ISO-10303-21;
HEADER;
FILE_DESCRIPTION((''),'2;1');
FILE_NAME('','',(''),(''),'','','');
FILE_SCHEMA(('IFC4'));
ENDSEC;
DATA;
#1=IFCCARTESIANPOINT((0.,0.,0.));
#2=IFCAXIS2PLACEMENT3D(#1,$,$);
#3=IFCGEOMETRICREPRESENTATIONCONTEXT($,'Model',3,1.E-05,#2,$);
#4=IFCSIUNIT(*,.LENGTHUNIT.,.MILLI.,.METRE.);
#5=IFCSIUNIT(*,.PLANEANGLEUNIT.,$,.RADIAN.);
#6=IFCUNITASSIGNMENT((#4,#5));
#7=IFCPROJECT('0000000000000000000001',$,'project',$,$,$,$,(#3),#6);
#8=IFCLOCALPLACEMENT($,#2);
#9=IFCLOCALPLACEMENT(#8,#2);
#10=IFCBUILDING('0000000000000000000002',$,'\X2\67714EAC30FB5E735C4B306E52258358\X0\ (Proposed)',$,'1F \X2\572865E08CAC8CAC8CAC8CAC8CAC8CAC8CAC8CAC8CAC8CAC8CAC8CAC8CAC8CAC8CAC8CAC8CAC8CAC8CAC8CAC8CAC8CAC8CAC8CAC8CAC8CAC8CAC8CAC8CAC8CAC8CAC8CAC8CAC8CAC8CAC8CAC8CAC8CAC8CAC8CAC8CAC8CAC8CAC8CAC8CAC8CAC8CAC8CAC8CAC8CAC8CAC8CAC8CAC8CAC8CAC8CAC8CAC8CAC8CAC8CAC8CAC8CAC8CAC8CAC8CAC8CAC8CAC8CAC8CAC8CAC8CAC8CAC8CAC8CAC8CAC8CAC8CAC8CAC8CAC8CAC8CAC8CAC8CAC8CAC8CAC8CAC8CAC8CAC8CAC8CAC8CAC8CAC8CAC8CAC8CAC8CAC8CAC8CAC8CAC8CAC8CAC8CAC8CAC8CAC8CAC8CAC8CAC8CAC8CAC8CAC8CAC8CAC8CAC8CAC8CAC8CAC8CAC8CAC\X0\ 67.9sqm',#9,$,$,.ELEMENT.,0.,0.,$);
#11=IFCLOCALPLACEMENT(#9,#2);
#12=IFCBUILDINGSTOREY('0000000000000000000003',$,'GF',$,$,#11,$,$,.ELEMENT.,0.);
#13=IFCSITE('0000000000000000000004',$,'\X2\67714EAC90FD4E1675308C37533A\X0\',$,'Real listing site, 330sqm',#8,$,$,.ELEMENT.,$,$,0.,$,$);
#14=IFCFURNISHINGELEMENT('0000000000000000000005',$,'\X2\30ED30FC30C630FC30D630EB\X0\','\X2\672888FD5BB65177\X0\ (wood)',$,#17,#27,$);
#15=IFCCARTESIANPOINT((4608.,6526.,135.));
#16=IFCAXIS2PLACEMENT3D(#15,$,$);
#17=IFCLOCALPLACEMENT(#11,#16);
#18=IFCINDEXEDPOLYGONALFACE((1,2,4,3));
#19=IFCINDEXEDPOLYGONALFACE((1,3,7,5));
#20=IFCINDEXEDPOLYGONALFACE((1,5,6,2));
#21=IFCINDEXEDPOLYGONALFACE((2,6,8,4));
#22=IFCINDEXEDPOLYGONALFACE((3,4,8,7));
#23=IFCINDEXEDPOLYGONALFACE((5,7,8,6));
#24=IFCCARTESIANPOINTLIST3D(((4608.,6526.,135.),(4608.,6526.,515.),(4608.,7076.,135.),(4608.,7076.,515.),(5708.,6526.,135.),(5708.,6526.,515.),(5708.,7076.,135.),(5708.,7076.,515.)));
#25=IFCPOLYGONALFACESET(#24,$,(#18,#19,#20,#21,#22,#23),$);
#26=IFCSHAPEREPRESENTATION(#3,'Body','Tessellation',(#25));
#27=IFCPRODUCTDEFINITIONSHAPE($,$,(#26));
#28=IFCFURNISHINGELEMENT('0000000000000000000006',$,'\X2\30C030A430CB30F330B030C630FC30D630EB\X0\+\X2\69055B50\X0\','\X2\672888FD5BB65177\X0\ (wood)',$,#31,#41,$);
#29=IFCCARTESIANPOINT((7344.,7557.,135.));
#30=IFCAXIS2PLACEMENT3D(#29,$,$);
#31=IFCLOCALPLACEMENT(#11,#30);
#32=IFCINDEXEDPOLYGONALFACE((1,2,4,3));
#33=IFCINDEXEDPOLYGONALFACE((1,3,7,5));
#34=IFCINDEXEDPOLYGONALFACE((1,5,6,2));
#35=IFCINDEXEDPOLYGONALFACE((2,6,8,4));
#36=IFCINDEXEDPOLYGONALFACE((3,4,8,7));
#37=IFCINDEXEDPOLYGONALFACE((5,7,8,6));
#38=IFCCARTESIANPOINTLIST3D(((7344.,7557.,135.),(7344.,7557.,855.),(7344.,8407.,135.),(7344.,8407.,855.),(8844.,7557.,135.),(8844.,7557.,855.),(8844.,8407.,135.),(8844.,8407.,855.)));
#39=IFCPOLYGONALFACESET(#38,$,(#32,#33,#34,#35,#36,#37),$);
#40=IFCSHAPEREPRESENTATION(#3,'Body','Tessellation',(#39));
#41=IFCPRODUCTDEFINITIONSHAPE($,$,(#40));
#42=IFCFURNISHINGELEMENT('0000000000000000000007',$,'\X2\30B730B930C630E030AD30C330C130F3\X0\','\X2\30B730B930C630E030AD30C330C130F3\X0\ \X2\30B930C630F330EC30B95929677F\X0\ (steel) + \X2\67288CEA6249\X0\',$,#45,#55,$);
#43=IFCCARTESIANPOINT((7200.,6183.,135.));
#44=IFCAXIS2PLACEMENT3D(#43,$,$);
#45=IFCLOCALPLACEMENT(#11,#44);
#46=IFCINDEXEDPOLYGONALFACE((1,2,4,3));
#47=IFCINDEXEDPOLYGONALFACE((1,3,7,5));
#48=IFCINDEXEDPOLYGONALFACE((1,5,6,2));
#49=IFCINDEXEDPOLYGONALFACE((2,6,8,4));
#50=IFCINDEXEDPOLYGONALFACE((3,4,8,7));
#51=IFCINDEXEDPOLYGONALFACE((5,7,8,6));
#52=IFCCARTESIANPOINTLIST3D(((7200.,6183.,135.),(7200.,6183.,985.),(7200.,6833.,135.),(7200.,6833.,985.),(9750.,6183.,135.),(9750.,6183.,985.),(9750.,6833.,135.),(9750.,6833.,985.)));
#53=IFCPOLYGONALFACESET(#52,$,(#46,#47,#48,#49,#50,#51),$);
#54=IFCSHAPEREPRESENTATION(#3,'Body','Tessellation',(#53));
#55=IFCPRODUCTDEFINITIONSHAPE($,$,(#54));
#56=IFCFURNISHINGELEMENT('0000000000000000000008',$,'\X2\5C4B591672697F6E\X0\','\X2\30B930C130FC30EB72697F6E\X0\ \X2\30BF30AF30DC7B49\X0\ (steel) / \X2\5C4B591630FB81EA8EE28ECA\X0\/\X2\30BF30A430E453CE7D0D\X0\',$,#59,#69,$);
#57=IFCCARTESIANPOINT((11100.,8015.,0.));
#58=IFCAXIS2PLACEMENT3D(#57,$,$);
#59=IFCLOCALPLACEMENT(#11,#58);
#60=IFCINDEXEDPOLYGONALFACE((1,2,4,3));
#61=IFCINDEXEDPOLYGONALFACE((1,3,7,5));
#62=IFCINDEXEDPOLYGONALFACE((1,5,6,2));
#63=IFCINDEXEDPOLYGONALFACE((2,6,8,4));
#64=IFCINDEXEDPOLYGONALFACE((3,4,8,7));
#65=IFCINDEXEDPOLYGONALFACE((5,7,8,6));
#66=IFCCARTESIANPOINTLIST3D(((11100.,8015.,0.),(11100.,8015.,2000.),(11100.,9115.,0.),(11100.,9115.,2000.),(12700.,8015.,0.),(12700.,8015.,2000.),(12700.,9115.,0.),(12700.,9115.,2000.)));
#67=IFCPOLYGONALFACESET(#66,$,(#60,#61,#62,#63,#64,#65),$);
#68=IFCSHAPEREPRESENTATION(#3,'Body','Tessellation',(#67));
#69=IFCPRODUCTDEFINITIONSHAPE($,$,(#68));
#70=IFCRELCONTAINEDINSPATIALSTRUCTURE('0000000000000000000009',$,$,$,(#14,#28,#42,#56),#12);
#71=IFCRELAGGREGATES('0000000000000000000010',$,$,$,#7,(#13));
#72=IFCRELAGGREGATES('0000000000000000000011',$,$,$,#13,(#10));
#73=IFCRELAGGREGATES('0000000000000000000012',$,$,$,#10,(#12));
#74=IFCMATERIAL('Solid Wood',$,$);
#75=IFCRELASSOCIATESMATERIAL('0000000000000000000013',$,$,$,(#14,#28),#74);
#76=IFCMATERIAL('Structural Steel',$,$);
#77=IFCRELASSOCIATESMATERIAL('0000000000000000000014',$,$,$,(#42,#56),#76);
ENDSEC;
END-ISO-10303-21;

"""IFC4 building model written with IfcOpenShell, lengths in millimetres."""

from ifc_helpers import new_model, si_unit, frame, frame_2d, origin, place, context, project, spatial, rectangle, extrude, material, element, save


model = new_model("IFC4")

# Units and contexts
model_context = context("Model", 3, precision=1e-05, world=origin())
ifc_project = project(units=[si_unit("LENGTHUNIT", "METRE", prefix="MILLI"), si_unit("PLANEANGLEUNIT", "RADIAN")], contexts=[model_context])

# Site, building, storey
site_placement = place(None, origin())
site = spatial("IfcSite", under=ifc_project, at=site_placement, Name="東京都世田谷区", ObjectType="Real listing site, 330sqm", CompositionType="ELEMENT", RefElevation=0.0)
building_placement = place(site_placement, origin())
building = spatial("IfcBuilding", under=site, at=building_placement, Name="東京・平屋の別荘 (Proposed)", ObjectType="1F 在无責責責責責責責責責責責責責責責責責責責責責責責責責責責責責責責責責責責責責責責責責責責責責責責責責責責責責責責責責責責責責責責責責責責責責責責責責責責責責責責責責責責責責責責責責責責責責責責責責責責責責責責責責責責責責責責責責責責責責責 67.9sqm", CompositionType="ELEMENT", ElevationOfRefHeight=0.0, ElevationOfTerrain=0.0)
storey_placement = place(building_placement, origin())
storey = spatial("IfcBuildingStorey", under=building, at=storey_placement, Name="GF", CompositionType="ELEMENT", Elevation=0.0)

# Shared definitions
ifc_material_1 = material(Name="Solid Wood")

# Shared definitions
ifc_material_2 = material(Name="Structural Steel")

# Furnishing elements
furnishing_1_placement = place(storey_placement, frame((4608.0, 6526.0, 135.0)))
element("IfcFurnishingElement", 1, at=furnishing_1_placement, inside=storey, material=ifc_material_1, Name="ローテーブル", Description="木製家具 (wood)", context=model_context, shape_type="SweptSolid", body=[
    extrude(rectangle(XDim=1100.0, YDim=550.0, at=frame_2d((550.0, 275.0))), frame((4608.0, 6526.0, 135.0)), (0.0, 0.0, 1.0), 380.0),
])
furnishing_2_placement = place(storey_placement, frame((7344.0, 7557.0, 135.0)))
element("IfcFurnishingElement", 2, at=furnishing_2_placement, inside=storey, material=ifc_material_1, Name="ダイニングテーブル+椅子", Description="木製家具 (wood)", context=model_context, shape_type="SweptSolid", body=[
    extrude(rectangle(XDim=1500.0, YDim=850.0, at=frame_2d((750.0, 425.0))), frame((7344.0, 7557.0, 135.0)), (0.0, 0.0, 1.0), 720.0),
])
furnishing_3_placement = place(storey_placement, frame((7200.0, 6183.0, 135.0)))
element("IfcFurnishingElement", 3, at=furnishing_3_placement, inside=storey, material=ifc_material_2, Name="システムキッチン", Description="システムキッチン ステンレス天板 (steel) + 木質扉", context=model_context, shape_type="SweptSolid", body=[
    extrude(rectangle(XDim=2550.0, YDim=650.0, at=frame_2d((1275.0, 325.0))), frame((7200.0, 6183.0, 135.0)), (0.0, 0.0, 1.0), 850.0),
])
furnishing_4_placement = place(storey_placement, frame((11100.0, 8015.0, 0.0)))
element("IfcFurnishingElement", 4, at=furnishing_4_placement, inside=storey, material=ifc_material_2, Name="屋外物置", Description="スチール物置 タクボ等 (steel) / 屋外・自転車/タイヤ収納", context=model_context, shape_type="SweptSolid", body=[
    extrude(rectangle(XDim=1600.0, YDim=1100.0, at=frame_2d((800.0, 550.0))), frame((11100.0, 8015.0, 0.0)), (0.0, 0.0, 1.0), 2000.0),
])

save(model, "model.ifc")
